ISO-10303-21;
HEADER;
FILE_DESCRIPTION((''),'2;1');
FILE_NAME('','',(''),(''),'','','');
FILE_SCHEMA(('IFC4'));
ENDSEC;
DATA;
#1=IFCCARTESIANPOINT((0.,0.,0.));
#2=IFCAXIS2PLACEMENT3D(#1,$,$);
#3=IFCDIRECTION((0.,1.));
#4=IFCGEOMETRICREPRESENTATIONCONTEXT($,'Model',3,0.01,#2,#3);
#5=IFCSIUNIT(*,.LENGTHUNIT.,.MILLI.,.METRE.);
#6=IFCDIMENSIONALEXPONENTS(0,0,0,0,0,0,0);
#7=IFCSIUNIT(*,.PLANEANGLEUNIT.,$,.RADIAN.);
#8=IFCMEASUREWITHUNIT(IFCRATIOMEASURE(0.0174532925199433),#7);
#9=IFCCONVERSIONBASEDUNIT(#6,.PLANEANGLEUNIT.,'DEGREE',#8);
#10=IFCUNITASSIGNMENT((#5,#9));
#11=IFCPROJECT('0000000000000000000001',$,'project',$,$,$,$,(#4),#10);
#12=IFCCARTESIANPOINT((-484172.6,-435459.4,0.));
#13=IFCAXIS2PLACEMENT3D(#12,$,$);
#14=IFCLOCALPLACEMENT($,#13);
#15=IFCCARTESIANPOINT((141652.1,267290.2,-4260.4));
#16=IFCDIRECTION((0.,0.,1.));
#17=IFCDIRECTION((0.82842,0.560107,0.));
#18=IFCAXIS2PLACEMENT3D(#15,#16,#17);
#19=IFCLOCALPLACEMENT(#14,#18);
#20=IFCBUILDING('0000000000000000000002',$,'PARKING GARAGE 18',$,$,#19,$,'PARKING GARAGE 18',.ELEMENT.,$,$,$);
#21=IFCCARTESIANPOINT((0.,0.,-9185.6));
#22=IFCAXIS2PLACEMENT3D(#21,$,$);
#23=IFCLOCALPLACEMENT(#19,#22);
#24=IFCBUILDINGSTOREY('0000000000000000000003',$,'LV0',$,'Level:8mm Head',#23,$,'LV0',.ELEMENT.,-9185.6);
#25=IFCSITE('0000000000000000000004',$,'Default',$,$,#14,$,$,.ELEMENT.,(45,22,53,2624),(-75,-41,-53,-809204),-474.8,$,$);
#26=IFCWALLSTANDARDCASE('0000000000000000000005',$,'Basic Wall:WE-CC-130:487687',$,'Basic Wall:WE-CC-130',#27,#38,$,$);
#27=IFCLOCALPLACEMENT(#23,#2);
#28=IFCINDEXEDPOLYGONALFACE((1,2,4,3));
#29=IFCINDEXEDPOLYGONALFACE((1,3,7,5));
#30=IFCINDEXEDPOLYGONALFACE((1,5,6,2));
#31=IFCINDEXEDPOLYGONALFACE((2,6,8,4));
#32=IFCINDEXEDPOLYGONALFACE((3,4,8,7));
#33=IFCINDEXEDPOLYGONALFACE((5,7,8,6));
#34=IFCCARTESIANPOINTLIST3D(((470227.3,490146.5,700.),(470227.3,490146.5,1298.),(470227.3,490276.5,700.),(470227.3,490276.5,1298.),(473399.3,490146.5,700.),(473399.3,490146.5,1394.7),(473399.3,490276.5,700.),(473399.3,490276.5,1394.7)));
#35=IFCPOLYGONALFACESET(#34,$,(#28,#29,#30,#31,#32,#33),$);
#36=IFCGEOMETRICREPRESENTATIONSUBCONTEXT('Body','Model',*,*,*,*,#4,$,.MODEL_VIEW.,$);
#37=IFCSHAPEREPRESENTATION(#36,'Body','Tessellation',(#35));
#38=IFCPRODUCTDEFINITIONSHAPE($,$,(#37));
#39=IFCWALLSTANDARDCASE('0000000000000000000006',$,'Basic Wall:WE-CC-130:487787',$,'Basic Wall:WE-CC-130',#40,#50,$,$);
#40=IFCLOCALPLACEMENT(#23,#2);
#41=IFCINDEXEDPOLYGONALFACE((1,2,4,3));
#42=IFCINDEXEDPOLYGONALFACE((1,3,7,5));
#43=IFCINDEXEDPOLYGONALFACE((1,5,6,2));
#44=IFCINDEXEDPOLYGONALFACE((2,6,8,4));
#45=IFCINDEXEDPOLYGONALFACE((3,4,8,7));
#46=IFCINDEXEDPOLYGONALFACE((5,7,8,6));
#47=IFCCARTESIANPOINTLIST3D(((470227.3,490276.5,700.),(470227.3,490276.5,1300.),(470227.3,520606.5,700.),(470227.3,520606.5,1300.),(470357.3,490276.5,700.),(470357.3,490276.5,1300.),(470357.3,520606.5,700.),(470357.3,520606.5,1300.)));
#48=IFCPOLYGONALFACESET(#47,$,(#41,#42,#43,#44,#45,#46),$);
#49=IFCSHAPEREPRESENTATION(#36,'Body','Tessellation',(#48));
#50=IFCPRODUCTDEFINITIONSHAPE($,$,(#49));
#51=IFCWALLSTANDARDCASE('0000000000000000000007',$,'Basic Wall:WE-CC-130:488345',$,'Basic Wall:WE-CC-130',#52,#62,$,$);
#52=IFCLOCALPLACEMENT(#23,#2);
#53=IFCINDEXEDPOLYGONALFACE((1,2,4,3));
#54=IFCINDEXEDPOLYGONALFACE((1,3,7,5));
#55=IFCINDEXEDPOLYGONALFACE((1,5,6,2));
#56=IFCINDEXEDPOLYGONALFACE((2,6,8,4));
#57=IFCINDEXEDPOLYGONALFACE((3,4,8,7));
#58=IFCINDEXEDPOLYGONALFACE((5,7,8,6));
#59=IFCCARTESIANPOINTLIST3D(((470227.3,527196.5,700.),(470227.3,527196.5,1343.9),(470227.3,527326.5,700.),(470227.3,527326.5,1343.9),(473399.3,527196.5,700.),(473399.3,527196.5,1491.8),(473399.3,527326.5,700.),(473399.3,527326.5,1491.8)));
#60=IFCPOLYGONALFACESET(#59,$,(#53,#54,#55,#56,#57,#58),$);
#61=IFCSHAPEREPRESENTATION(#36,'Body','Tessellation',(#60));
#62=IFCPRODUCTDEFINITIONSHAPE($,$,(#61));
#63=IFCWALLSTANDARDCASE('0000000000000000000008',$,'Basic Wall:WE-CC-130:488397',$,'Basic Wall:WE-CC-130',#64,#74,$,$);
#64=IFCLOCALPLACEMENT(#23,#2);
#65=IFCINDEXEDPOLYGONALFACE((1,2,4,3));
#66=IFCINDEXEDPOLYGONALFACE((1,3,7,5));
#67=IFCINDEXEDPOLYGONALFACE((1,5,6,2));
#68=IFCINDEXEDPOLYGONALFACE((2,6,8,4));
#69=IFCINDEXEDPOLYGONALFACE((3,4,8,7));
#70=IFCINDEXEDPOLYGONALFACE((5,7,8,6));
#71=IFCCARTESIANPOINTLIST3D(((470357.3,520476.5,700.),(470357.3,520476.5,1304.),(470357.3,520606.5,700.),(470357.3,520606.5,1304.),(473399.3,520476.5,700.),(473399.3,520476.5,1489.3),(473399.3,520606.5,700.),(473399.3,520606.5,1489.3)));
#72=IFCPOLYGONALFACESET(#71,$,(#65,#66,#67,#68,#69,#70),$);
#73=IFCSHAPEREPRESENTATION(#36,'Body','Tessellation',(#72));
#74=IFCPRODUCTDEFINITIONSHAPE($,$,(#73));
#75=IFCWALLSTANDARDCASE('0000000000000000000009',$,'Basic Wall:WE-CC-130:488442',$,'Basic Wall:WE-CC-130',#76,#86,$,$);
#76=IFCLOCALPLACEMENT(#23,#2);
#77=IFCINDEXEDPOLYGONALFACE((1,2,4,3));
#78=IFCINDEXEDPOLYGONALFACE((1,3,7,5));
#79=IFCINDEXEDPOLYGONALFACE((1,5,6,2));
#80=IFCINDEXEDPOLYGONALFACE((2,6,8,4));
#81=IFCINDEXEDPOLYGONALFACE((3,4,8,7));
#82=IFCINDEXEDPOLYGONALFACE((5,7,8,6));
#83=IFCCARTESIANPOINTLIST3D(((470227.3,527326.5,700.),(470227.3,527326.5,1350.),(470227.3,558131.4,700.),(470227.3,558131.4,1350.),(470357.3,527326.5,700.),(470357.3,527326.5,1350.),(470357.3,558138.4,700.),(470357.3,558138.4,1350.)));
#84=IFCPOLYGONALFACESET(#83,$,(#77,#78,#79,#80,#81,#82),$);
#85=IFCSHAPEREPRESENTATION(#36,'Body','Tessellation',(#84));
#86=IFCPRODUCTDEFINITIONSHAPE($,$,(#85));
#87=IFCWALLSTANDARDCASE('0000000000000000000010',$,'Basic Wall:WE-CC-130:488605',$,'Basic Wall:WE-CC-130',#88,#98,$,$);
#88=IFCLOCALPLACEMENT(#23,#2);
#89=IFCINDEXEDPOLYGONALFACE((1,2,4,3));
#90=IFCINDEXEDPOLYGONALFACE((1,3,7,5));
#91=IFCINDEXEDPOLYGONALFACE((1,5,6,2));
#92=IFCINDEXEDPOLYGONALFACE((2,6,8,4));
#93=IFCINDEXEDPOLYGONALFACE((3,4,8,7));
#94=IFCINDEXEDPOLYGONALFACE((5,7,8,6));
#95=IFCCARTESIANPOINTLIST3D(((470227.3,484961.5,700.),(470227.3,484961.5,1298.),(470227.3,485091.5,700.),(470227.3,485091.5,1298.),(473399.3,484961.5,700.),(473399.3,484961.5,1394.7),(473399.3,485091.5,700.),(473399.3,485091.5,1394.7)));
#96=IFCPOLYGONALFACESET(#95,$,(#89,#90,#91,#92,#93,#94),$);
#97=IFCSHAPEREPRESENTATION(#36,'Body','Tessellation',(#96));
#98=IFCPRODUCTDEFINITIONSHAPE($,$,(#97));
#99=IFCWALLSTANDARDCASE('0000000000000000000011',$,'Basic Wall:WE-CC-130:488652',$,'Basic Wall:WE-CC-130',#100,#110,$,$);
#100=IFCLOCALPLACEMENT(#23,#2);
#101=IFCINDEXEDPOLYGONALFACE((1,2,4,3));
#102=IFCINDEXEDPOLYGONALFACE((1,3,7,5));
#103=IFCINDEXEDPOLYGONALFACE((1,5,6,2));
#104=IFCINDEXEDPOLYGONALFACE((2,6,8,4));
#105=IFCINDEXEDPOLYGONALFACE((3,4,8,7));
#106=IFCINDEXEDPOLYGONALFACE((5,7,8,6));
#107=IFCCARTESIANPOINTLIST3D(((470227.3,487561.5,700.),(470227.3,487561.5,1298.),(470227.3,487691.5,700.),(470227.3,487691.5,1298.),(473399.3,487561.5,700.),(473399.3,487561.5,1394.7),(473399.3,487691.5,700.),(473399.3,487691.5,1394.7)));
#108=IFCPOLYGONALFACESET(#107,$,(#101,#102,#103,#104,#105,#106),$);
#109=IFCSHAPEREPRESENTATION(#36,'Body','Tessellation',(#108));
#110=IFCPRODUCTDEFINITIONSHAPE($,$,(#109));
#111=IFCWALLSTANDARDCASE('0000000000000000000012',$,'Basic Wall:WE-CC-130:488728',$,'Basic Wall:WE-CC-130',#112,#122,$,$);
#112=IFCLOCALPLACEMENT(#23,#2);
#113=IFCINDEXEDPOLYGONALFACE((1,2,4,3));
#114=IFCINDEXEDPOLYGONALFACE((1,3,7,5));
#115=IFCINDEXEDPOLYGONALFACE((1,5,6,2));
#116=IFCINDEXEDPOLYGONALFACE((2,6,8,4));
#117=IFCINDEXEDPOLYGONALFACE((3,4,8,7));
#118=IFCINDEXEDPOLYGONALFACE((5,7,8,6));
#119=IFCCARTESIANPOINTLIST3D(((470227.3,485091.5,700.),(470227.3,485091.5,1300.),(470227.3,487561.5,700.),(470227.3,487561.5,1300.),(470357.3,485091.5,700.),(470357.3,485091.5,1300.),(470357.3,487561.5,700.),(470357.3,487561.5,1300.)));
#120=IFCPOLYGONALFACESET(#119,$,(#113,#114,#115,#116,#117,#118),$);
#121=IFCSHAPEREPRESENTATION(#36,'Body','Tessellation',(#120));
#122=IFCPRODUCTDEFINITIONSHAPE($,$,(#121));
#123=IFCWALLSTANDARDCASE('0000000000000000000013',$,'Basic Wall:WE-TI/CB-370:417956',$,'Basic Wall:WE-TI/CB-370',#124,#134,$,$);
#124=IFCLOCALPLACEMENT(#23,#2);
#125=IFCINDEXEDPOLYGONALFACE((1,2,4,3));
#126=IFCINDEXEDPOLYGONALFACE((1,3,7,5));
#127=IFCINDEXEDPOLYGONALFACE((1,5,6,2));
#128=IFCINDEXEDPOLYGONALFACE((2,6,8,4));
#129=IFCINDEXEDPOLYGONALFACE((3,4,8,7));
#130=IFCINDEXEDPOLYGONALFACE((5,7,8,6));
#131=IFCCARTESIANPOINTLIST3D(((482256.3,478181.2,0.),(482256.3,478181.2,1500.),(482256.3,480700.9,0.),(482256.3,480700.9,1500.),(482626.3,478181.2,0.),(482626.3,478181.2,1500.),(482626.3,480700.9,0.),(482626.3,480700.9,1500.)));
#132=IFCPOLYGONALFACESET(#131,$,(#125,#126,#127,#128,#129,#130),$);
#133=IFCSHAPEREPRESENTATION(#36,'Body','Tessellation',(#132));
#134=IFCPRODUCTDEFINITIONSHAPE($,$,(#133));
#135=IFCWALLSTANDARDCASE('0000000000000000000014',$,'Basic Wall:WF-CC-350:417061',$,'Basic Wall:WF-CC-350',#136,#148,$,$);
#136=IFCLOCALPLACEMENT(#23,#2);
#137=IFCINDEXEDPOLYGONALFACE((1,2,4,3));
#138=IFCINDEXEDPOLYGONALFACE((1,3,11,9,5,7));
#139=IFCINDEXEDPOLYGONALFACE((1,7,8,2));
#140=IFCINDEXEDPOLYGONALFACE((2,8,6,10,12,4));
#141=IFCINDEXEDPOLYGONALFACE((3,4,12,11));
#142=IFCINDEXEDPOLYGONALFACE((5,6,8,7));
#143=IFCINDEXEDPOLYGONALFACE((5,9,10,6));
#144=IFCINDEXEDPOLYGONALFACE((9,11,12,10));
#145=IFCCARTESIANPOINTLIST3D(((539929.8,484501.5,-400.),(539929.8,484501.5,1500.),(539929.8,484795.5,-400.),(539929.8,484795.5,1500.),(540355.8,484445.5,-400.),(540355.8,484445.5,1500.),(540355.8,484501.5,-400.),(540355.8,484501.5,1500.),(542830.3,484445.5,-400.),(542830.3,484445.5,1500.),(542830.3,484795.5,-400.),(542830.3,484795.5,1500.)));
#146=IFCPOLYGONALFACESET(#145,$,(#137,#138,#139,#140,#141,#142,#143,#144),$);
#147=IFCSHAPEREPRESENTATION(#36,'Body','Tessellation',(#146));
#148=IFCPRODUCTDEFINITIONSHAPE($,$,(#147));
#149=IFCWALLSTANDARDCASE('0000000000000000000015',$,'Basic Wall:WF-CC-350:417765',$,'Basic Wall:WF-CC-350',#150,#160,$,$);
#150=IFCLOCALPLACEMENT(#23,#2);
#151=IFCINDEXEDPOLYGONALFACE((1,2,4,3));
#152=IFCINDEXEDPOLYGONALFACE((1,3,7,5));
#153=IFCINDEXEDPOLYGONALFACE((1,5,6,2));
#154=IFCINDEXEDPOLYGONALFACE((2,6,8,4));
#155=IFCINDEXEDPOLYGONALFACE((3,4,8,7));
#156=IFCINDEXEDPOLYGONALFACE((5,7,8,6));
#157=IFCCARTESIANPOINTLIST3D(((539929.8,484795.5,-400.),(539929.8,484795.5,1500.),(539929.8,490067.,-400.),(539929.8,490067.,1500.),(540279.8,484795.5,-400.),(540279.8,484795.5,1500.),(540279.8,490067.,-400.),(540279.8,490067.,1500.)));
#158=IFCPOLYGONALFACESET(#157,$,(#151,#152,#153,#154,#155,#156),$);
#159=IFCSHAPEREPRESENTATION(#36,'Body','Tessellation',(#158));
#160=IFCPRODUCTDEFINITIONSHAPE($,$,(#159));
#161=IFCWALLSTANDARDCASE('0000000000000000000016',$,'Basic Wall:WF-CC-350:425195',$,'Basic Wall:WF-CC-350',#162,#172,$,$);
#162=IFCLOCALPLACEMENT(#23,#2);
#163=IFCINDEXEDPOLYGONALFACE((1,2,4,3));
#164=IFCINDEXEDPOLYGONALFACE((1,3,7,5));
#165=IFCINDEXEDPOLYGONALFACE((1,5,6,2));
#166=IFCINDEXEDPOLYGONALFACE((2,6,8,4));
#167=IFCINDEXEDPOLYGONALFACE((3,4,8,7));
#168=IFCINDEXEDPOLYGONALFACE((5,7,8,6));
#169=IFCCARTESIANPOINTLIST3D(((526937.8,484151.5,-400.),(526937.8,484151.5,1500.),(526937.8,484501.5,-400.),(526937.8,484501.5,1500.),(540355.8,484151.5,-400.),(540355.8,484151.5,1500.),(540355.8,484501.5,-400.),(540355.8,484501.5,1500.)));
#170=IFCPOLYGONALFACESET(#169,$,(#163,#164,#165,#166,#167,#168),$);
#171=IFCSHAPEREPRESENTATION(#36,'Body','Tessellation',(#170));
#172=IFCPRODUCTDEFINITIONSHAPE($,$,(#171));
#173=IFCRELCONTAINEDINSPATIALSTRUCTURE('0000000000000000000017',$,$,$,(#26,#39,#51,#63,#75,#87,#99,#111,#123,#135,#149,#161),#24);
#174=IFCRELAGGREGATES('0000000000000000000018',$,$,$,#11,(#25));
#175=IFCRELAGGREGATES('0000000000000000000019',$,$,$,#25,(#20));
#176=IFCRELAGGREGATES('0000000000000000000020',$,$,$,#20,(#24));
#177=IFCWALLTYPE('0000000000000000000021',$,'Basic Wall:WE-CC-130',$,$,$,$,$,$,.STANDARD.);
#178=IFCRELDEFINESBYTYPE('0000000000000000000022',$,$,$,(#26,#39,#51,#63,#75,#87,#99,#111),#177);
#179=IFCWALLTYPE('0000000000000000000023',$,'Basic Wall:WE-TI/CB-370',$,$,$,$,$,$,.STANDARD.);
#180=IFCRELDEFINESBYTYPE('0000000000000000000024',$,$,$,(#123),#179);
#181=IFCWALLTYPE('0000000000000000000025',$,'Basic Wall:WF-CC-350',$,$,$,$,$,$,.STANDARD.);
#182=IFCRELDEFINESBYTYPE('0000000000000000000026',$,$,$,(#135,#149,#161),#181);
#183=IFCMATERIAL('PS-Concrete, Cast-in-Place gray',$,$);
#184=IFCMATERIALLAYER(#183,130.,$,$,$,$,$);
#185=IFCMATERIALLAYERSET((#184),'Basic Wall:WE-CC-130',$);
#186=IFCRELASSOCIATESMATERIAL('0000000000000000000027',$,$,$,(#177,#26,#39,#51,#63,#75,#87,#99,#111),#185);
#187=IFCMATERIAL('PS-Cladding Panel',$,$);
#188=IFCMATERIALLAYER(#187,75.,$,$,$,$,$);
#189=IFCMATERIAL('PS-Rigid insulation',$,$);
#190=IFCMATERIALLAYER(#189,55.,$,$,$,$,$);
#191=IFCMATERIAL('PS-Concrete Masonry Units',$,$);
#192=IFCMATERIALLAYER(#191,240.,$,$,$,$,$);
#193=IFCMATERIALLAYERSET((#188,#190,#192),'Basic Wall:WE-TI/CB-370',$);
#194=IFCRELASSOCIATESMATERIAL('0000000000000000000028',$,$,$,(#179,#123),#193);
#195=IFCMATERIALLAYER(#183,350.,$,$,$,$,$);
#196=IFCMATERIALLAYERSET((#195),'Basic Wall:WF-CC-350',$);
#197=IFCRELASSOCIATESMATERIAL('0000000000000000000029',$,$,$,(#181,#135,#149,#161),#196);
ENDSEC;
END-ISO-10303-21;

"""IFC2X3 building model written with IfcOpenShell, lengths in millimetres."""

from ifc_helpers import new_model, entity, si_unit, converted_unit, direction, frame, frame_2d, origin, place, context, subcontext, project, spatial, polyline, rectangle, outline, extrude, clip, halfspace, bounded_halfspace, material, layer, layer_set, layer_usage, type_object, element, save


model = new_model("IFC2X3")

# Units and contexts
model_context = context("Model", 3, precision=0.01, world=origin(), true_north=direction((0.0, 1.0)))
body_context = subcontext(model_context, "Body", "Model", "MODEL_VIEW")
ifc_project = project(units=[si_unit("LENGTHUNIT", "METRE", prefix="MILLI"), converted_unit("PLANEANGLEUNIT", "DEGREE", entity("IfcRatioMeasure", 0.0174532925199433), si_unit("PLANEANGLEUNIT", "RADIAN"), dimensions=[0, 0, 0, 0, 0, 0, 0])], contexts=[model_context])

# Site, building, storey
site_placement = place(None, frame((-484172.6, -435459.4, 0.0)))
site = spatial("IfcSite", under=ifc_project, at=site_placement, Name="Default", CompositionType="ELEMENT", RefLatitude=(45, 22, 53, 2624), RefLongitude=(-75, -41, -53, -809204), RefElevation=-474.8)
building_placement = place(site_placement, frame((141652.1, 267290.2, -4260.4), z_axis=(0.0, 0.0, 1.0), x_axis=(0.82842, 0.560107, 0.0)))
building = spatial("IfcBuilding", under=site, at=building_placement, Name="PARKING GARAGE 18", LongName="PARKING GARAGE 18", CompositionType="ELEMENT")
storey_placement = place(building_placement, frame((0.0, 0.0, -9185.6)))
storey = spatial("IfcBuildingStorey", under=building, at=storey_placement, Name="LV0", ObjectType="Level:8mm Head", LongName="LV0", CompositionType="ELEMENT", Elevation=-9185.6)

# Walls
ifc_material_1 = material(Name="PS-Concrete, Cast-in-Place gray")
ifc_layer_1 = layer(ifc_material_1, 130.0)
ifc_layer_set_1 = layer_set([ifc_layer_1], Name="Basic Wall:WE-CC-130")
ifc_layer_usage_1 = layer_usage(ifc_layer_set_1, "AXIS2", "NEGATIVE", 65.0)
wall_type_1 = type_object("IfcWallType", Name="Basic Wall:WE-CC-130", PredefinedType="STANDARD", material=ifc_layer_set_1)
wall_1_placement = place(storey_placement, frame((473399.3, 490211.5, 700.0), z_axis=(0.0, 0.0, 1.0), x_axis=(-1.0, 0.0, 0.0)))
element("IfcWallStandardCase", 1, at=wall_1_placement, inside=storey, type_object=wall_type_1, material=ifc_layer_usage_1, Name="Basic Wall:WE-CC-130:487687", ObjectType="Basic Wall:WE-CC-130", context=body_context, shape_type="Clipping", body=[
    clip(extrude(rectangle(XDim=3172.0, YDim=130.0, at=frame_2d((1586.0, 0.0), x_axis=(-1.0, 0.0))), origin(), (0.0, 0.0, 1.0), 694.7), halfspace(frame((0.0, -65.0, 694.7), z_axis=(0.030455, 0.0, 0.999536), x_axis=(0.0, 1.0, 0.0)), False)),
])
ifc_layer_usage_2 = layer_usage(ifc_layer_set_1, "AXIS2", "NEGATIVE", 65.0)
wall_2_placement = place(storey_placement, frame((470292.3, 490276.5, 700.0), z_axis=(0.0, 0.0, 1.0), x_axis=(0.0, 1.0, 0.0)))
element("IfcWallStandardCase", 2, at=wall_2_placement, inside=storey, type_object=wall_type_1, material=ifc_layer_usage_2, Name="Basic Wall:WE-CC-130:487787", ObjectType="Basic Wall:WE-CC-130", context=body_context, shape_type="Clipping", body=[
    clip(extrude(rectangle(XDim=30330.1, YDim=130.0, at=frame_2d((15165.0, 0.0), x_axis=(-1.0, 0.0))), origin(), (0.0, 0.0, 1.0), 600.0), halfspace(frame((0.0, -65.0, 600.0), z_axis=(0.0, 0.0, 1.0), x_axis=(0.0, 1.0, 0.0)), False)),
])
ifc_layer_usage_3 = layer_usage(ifc_layer_set_1, "AXIS2", "NEGATIVE", 65.0)
wall_3_placement = place(storey_placement, frame((473399.3, 527261.5, 700.0), z_axis=(0.0, 0.0, 1.0), x_axis=(-1.0, 0.0, 0.0)))
element("IfcWallStandardCase", 3, at=wall_3_placement, inside=storey, type_object=wall_type_1, material=ifc_layer_usage_3, Name="Basic Wall:WE-CC-130:488345", ObjectType="Basic Wall:WE-CC-130", context=body_context, shape_type="Clipping", body=[
    clip(extrude(rectangle(XDim=3172.0, YDim=130.0, at=frame_2d((1586.0, 0.0), x_axis=(-1.0, 0.0))), origin(), (0.0, 0.0, 1.0), 791.8), halfspace(frame((0.0, -65.0, 791.8), z_axis=(0.046577, 0.0, 0.998915), x_axis=(0.0, 1.0, 0.0)), False)),
])
ifc_layer_usage_4 = layer_usage(ifc_layer_set_1, "AXIS2", "POSITIVE", -65.0)
wall_4_placement = place(storey_placement, frame((473399.3, 520541.5, 700.0), z_axis=(0.0, 0.0, 1.0), x_axis=(-1.0, 0.0, 0.0)))
element("IfcWallStandardCase", 4, at=wall_4_placement, inside=storey, type_object=wall_type_1, material=ifc_layer_usage_4, Name="Basic Wall:WE-CC-130:488397", ObjectType="Basic Wall:WE-CC-130", context=body_context, shape_type="Clipping", body=[
    clip(extrude(rectangle(XDim=3042.0, YDim=130.0, at=frame_2d((1521.0, 0.0), x_axis=(-1.0, 0.0))), origin(), (0.0, 0.0, 1.0), 789.3), halfspace(frame((0.0, -65.0, 789.3), z_axis=(0.060825, 0.0, 0.998148), x_axis=(0.0, 1.0, 0.0)), False)),
])
ifc_layer_usage_5 = layer_usage(ifc_layer_set_1, "AXIS2", "NEGATIVE", 65.0)
wall_5_placement = place(storey_placement, frame((470292.3, 527326.5, 700.0), z_axis=(0.0, 0.0, 1.0), x_axis=(0.0, 1.0, 0.0)))
element("IfcWallStandardCase", 5, at=wall_5_placement, inside=storey, type_object=wall_type_1, material=ifc_layer_usage_5, Name="Basic Wall:WE-CC-130:488442", ObjectType="Basic Wall:WE-CC-130", context=body_context, shape_type="SweptSolid", body=[
    extrude(outline(polyline([(30811.9, -65.0), (30804.8, 65.0), (0.0, 65.0), (0.0, -65.0), (30811.9, -65.0)])), origin(), (0.0, 0.0, 1.0), 650.0),
])
ifc_layer_usage_6 = layer_usage(ifc_layer_set_1, "AXIS2", "NEGATIVE", 65.0)
wall_6_placement = place(storey_placement, frame((473399.3, 485026.5, 700.0), z_axis=(0.0, 0.0, 1.0), x_axis=(-1.0, 0.0, 0.0)))
element("IfcWallStandardCase", 6, at=wall_6_placement, inside=storey, type_object=wall_type_1, material=ifc_layer_usage_6, Name="Basic Wall:WE-CC-130:488605", ObjectType="Basic Wall:WE-CC-130", context=body_context, shape_type="Clipping", body=[
    clip(extrude(rectangle(XDim=3172.0, YDim=130.0, at=frame_2d((1586.0, 0.0), x_axis=(-1.0, 0.0))), origin(), (0.0, 0.0, 1.0), 694.7), halfspace(frame((0.0, -65.0, 694.7), z_axis=(0.030455, 0.0, 0.999536), x_axis=(0.0, 1.0, 0.0)), False)),
])
ifc_layer_usage_7 = layer_usage(ifc_layer_set_1, "AXIS2", "POSITIVE", -65.0)
wall_7_placement = place(storey_placement, frame((473399.3, 487626.5, 700.0), z_axis=(0.0, 0.0, 1.0), x_axis=(-1.0, 0.0, 0.0)))
element("IfcWallStandardCase", 7, at=wall_7_placement, inside=storey, type_object=wall_type_1, material=ifc_layer_usage_7, Name="Basic Wall:WE-CC-130:488652", ObjectType="Basic Wall:WE-CC-130", context=body_context, shape_type="Clipping", body=[
    clip(extrude(rectangle(XDim=3172.0, YDim=130.0, at=frame_2d((1586.0, 0.0), x_axis=(-1.0, 0.0))), origin(), (0.0, 0.0, 1.0), 694.7), halfspace(frame((0.0, -65.0, 694.7), z_axis=(0.030455, 0.0, 0.999536), x_axis=(0.0, 1.0, 0.0)), False)),
])
ifc_layer_usage_8 = layer_usage(ifc_layer_set_1, "AXIS2", "NEGATIVE", 65.0)
wall_8_placement = place(storey_placement, frame((470292.3, 485091.5, 700.0), z_axis=(0.0, 0.0, 1.0), x_axis=(0.0, 1.0, 0.0)))
element("IfcWallStandardCase", 8, at=wall_8_placement, inside=storey, type_object=wall_type_1, material=ifc_layer_usage_8, Name="Basic Wall:WE-CC-130:488728", ObjectType="Basic Wall:WE-CC-130", context=body_context, shape_type="SweptSolid", body=[
    extrude(rectangle(XDim=2470.0, YDim=130.0, at=frame_2d((1235.0, 0.0), x_axis=(-1.0, 0.0))), origin(), (0.0, 0.0, 1.0), 600.0),
])
ifc_material_2 = material(Name="PS-Cladding Panel")
ifc_layer_2 = layer(ifc_material_2, 75.0)
ifc_material_3 = material(Name="PS-Rigid insulation")
ifc_layer_3 = layer(ifc_material_3, 55.0)
ifc_material_4 = material(Name="PS-Concrete Masonry Units")
ifc_layer_4 = layer(ifc_material_4, 240.0)
ifc_layer_set_2 = layer_set([ifc_layer_2, ifc_layer_3, ifc_layer_4], Name="Basic Wall:WE-TI/CB-370")
ifc_layer_usage_9 = layer_usage(ifc_layer_set_2, "AXIS2", "NEGATIVE", 185.0)
wall_type_2 = type_object("IfcWallType", Name="Basic Wall:WE-TI/CB-370", PredefinedType="STANDARD", material=ifc_layer_set_2)
wall_9_placement = place(storey_placement, frame((482441.3, 478181.2, 0.0), z_axis=(0.0, 0.0, 1.0), x_axis=(0.0, 1.0, 0.0)))
element("IfcWallStandardCase", 9, at=wall_9_placement, inside=storey, type_object=wall_type_2, material=ifc_layer_usage_9, Name="Basic Wall:WE-TI/CB-370:417956", ObjectType="Basic Wall:WE-TI/CB-370", context=body_context, shape_type="SweptSolid", body=[
    extrude(rectangle(XDim=2519.7, YDim=370.0, at=frame_2d((1259.8, 0.0), x_axis=(-1.0, 0.0))), origin(), (0.0, 0.0, 1.0), 1500.0),
])
ifc_layer_5 = layer(ifc_material_1, 350.0)
ifc_layer_set_3 = layer_set([ifc_layer_5], Name="Basic Wall:WF-CC-350")
ifc_layer_usage_10 = layer_usage(ifc_layer_set_3, "AXIS2", "NEGATIVE", 175.0)
wall_type_3 = type_object("IfcWallType", Name="Basic Wall:WF-CC-350", PredefinedType="STANDARD", material=ifc_layer_set_3)
wall_10_placement = place(storey_placement, frame((542830.3, 484620.5, -400.0), z_axis=(0.0, 0.0, 1.0), x_axis=(-1.0, 0.0, 0.0)))
element("IfcWallStandardCase", 10, at=wall_10_placement, inside=storey, type_object=wall_type_3, material=ifc_layer_usage_10, Name="Basic Wall:WF-CC-350:417061", ObjectType="Basic Wall:WF-CC-350", context=body_context, shape_type="Clipping", body=[
    clip(clip(extrude(rectangle(XDim=2900.5, YDim=350.0, at=frame_2d((1450.3, 0.0), x_axis=(-1.0, 0.0))), origin(), (0.0, 0.0, 1.0), 1900.0), bounded_halfspace(frame((2474.5, 119.0, 0.0), z_axis=(0.0, -1.0, 0.0), x_axis=(1.0, 0.0, 0.0)), True, frame((2474.5, 119.0, 0.0), z_axis=(0.0, -1.0, 0.0), x_axis=(1.0, 0.0, 0.0)), polyline([(0.0, 0.0), (426.0, 0.0), (426.0, 1900.0), (0.0, 1900.0), (0.0, 0.0)]))), bounded_halfspace(frame((2474.5, 119.0, 1900.0), z_axis=(-1.0, 0.0, 0.0), x_axis=(0.0, 1.0, 0.0)), True, frame((2474.5, 119.0, 1900.0), z_axis=(-1.0, 0.0, 0.0), x_axis=(0.0, 1.0, 0.0)), polyline([(0.0, 0.0), (56.0, 0.0), (56.0, 1900.0), (0.0, 1900.0), (0.0, 0.0)]))),
])
ifc_layer_usage_11 = layer_usage(ifc_layer_set_3, "AXIS2", "NEGATIVE", 175.0)
wall_11_placement = place(storey_placement, frame((540104.8, 484795.5, -400.0), z_axis=(0.0, 0.0, 1.0), x_axis=(0.0, 1.0, 0.0)))
element("IfcWallStandardCase", 11, at=wall_11_placement, inside=storey, type_object=wall_type_3, material=ifc_layer_usage_11, Name="Basic Wall:WF-CC-350:417765", ObjectType="Basic Wall:WF-CC-350", context=body_context, shape_type="SweptSolid", body=[
    extrude(rectangle(XDim=5271.5, YDim=350.0, at=frame_2d((2635.8, 0.0), x_axis=(-1.0, 0.0))), origin(), (0.0, 0.0, 1.0), 1900.0),
])
ifc_layer_usage_12 = layer_usage(ifc_layer_set_3, "AXIS2", "NEGATIVE", 175.0)
wall_12_placement = place(storey_placement, frame((540355.8, 484326.5, -400.0), z_axis=(0.0, 0.0, 1.0), x_axis=(-1.0, 0.0, 0.0)))
element("IfcWallStandardCase", 12, at=wall_12_placement, inside=storey, type_object=wall_type_3, material=ifc_layer_usage_12, Name="Basic Wall:WF-CC-350:425195", ObjectType="Basic Wall:WF-CC-350", context=body_context, shape_type="SweptSolid", body=[
    extrude(rectangle(XDim=13418.0, YDim=350.0, at=frame_2d((6709.0, 0.0), x_axis=(-1.0, 0.0))), origin(), (0.0, 0.0, 1.0), 1900.0),
])

save(model, "model.ifc")
